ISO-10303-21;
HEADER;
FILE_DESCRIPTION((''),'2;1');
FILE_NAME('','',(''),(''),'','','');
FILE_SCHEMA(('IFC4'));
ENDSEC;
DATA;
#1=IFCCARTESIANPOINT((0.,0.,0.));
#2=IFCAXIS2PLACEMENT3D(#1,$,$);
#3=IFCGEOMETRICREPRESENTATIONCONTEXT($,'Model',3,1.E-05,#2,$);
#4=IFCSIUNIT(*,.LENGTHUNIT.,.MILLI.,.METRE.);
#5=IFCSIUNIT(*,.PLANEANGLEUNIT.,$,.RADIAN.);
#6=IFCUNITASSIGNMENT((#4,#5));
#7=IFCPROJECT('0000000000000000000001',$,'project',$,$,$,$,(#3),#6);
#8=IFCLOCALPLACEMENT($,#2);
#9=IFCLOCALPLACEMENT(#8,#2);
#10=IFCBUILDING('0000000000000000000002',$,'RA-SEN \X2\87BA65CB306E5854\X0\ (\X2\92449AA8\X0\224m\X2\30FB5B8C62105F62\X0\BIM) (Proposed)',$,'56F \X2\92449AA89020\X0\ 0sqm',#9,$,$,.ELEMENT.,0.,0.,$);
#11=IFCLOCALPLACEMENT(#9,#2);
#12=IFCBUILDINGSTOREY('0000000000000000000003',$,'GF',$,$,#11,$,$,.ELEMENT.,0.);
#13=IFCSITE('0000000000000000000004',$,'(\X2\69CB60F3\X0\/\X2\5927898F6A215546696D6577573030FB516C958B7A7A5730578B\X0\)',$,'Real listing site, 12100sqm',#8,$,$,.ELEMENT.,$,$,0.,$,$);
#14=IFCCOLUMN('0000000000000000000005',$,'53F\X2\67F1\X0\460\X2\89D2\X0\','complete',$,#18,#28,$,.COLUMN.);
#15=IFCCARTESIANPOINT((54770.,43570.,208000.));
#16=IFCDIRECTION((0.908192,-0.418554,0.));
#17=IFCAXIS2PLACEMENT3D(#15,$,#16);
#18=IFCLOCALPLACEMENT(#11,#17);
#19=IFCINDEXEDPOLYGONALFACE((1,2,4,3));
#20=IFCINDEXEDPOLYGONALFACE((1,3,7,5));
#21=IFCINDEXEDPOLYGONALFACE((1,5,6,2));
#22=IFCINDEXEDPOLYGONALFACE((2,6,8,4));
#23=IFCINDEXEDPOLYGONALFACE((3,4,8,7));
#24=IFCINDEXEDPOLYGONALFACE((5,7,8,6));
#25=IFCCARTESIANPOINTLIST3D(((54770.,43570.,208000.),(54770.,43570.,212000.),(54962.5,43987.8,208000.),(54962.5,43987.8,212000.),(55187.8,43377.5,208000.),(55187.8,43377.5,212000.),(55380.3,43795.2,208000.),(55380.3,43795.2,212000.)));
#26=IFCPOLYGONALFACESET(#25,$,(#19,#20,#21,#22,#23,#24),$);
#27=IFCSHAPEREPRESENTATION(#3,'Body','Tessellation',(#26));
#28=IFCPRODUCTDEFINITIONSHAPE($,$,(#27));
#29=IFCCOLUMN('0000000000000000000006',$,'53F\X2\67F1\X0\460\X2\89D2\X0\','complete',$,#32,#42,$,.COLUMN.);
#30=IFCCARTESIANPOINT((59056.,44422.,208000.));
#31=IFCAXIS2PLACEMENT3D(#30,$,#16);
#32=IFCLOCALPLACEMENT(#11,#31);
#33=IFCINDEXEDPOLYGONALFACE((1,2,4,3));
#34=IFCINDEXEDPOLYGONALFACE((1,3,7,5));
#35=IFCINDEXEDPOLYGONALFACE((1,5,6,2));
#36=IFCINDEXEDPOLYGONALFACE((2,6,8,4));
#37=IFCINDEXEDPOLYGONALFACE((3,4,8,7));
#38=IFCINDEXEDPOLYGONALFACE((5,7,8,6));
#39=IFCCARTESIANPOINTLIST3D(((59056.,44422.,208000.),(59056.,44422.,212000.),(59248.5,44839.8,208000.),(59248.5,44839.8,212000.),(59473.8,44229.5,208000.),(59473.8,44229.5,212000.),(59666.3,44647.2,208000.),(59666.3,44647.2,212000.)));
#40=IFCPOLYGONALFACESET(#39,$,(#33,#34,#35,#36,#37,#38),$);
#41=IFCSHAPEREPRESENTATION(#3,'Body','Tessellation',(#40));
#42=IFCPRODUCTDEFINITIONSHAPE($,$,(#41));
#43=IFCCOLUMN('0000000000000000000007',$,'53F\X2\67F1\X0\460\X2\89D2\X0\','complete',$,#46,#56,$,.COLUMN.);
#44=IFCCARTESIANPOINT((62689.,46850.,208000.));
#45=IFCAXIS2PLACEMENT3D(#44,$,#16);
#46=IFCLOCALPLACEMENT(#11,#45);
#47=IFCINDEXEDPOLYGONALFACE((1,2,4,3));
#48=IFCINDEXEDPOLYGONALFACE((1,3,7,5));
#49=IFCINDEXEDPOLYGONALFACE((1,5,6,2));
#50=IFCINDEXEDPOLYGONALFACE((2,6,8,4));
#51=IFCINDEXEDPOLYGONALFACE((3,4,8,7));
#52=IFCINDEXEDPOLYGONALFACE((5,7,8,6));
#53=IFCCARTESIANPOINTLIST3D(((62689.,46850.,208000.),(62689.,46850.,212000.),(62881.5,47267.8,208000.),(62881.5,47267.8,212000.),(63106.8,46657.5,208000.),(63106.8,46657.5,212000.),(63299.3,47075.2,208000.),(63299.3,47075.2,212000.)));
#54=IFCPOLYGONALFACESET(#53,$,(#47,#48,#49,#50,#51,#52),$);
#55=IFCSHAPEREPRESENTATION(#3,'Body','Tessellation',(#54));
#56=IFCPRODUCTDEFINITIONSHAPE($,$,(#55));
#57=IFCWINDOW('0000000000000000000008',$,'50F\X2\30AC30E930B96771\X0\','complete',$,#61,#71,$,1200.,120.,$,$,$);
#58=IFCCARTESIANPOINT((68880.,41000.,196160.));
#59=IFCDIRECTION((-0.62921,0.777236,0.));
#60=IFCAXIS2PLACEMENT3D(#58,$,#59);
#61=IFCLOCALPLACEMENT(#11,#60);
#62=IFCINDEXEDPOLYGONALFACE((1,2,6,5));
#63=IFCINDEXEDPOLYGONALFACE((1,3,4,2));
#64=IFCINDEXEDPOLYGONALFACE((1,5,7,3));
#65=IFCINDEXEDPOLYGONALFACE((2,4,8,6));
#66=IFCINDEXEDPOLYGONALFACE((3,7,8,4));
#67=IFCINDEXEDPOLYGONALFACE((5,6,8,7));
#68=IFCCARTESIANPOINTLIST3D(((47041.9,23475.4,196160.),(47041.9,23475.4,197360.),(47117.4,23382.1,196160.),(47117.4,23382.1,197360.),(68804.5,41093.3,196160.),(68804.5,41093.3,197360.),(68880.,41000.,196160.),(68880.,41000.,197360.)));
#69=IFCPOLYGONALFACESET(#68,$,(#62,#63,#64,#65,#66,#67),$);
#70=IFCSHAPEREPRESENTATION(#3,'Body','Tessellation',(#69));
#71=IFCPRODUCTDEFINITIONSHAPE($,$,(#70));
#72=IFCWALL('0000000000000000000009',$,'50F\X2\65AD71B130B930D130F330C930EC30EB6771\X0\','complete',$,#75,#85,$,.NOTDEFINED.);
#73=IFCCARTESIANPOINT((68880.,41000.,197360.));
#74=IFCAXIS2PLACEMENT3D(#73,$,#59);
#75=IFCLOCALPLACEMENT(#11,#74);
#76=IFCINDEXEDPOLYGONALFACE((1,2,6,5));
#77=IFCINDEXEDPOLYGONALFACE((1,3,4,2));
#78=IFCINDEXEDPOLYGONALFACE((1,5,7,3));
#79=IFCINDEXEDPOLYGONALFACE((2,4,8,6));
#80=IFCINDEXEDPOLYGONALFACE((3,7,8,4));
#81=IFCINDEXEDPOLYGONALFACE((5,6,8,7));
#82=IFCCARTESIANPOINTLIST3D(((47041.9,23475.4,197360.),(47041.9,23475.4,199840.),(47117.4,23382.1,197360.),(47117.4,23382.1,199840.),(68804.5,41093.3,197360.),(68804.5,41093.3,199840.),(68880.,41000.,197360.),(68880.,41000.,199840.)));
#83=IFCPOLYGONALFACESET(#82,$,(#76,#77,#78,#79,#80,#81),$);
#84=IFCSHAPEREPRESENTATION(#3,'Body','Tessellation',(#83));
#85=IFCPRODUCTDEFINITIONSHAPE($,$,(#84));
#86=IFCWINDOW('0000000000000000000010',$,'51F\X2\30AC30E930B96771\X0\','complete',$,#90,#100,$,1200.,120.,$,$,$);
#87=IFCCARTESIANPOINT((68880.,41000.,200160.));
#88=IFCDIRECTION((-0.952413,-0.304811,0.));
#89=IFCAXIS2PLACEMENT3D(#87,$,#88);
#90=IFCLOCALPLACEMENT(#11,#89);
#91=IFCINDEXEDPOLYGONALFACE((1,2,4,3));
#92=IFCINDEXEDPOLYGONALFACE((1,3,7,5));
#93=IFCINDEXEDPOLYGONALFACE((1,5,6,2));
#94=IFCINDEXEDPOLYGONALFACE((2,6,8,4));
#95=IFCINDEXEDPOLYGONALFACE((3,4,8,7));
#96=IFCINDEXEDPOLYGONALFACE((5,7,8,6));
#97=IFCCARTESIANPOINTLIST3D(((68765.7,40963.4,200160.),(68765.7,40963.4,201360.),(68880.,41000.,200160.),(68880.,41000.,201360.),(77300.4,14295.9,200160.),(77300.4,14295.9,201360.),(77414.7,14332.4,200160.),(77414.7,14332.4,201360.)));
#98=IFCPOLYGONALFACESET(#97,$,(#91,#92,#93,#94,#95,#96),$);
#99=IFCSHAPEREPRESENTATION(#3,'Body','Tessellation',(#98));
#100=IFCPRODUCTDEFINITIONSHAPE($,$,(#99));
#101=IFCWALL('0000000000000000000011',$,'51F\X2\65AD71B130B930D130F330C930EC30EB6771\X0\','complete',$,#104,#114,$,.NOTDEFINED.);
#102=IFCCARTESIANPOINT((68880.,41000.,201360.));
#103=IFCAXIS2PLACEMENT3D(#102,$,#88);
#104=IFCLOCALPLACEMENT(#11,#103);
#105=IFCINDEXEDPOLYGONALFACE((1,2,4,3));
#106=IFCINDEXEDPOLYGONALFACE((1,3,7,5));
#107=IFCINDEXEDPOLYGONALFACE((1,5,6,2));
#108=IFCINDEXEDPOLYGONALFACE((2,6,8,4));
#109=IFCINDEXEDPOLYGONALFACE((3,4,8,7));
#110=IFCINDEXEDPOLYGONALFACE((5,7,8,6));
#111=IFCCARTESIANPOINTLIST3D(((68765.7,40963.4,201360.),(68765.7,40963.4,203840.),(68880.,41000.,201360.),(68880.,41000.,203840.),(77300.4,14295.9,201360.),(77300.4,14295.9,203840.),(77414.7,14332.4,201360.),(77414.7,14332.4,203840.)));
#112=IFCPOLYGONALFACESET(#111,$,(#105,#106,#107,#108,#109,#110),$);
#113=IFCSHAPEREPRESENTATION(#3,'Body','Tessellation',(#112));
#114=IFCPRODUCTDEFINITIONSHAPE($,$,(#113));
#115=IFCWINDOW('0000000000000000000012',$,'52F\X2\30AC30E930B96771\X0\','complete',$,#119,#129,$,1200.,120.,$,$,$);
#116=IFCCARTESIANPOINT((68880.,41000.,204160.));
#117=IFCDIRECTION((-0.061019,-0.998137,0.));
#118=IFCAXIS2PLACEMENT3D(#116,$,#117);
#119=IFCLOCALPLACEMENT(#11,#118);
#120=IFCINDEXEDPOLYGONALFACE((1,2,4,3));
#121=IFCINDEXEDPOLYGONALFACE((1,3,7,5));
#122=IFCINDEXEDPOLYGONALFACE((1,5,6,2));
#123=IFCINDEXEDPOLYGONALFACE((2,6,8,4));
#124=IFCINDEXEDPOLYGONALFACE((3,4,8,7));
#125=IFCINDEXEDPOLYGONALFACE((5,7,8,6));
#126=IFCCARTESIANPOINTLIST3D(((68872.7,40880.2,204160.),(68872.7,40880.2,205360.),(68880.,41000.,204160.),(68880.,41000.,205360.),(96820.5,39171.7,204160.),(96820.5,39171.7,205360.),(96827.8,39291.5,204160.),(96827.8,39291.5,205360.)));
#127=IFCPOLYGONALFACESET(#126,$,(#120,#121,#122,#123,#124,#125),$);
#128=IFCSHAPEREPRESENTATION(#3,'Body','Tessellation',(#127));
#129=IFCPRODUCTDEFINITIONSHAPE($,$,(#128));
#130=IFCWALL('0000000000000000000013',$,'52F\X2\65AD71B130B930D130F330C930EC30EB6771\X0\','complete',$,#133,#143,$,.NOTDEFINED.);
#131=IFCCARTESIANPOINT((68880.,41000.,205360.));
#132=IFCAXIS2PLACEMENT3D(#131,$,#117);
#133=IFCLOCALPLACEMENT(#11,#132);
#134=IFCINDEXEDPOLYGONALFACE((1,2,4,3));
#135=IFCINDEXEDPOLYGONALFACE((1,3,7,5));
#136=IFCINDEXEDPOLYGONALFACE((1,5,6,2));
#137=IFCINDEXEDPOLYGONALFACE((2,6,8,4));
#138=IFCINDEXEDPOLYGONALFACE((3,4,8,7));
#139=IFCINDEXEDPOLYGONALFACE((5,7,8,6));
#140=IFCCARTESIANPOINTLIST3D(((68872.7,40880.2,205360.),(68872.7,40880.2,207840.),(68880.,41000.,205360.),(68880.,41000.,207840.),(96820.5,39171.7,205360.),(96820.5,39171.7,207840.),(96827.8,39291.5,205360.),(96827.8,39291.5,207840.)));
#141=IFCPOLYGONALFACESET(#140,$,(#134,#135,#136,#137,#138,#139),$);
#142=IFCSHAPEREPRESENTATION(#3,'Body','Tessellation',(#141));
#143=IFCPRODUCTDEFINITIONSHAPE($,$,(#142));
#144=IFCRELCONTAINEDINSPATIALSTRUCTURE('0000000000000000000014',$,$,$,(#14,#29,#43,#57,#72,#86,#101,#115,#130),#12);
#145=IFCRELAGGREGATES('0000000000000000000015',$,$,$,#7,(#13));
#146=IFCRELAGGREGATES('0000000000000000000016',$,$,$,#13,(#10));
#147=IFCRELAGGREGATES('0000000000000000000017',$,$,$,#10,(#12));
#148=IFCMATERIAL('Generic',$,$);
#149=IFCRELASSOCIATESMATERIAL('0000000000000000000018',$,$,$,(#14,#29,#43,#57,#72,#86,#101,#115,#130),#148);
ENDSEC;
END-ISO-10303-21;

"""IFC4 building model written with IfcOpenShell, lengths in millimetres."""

from ifc_helpers import new_model, si_unit, frame, frame_2d, origin, place, context, project, spatial, rectangle, extrude, material, element, save


model = new_model("IFC4")

# Units and contexts
model_context = context("Model", 3, precision=1e-05, world=origin())
ifc_project = project(units=[si_unit("LENGTHUNIT", "METRE", prefix="MILLI"), si_unit("PLANEANGLEUNIT", "RADIAN")], contexts=[model_context])

# Site, building, storey
site_placement = place(None, origin())
site = spatial("IfcSite", under=ifc_project, at=site_placement, Name="(構想/大規模商業敷地・公開空地型)", ObjectType="Real listing site, 12100sqm", CompositionType="ELEMENT", RefElevation=0.0)
building_placement = place(site_placement, origin())
building = spatial("IfcBuilding", under=site, at=building_placement, Name="RA-SEN 螺旋の塔 (鉄骨224m・完成形BIM) (Proposed)", ObjectType="56F 鉄骨造 0sqm", CompositionType="ELEMENT", ElevationOfRefHeight=0.0, ElevationOfTerrain=0.0)
storey_placement = place(building_placement, origin())
storey = spatial("IfcBuildingStorey", under=building, at=storey_placement, Name="GF", CompositionType="ELEMENT", Elevation=0.0)

# Columns
ifc_material = material(Name="Generic")
column_1_placement = place(storey_placement, frame((54770.0, 43570.0, 208000.0), x_axis=(0.908192, -0.418554, 0.0)))
element("IfcColumn", 1, at=column_1_placement, inside=storey, material=ifc_material, Name="53F柱460角", Description="complete", PredefinedType="COLUMN", context=model_context, shape_type="SweptSolid", body=[
    extrude(rectangle(XDim=460.0, YDim=460.0, at=frame_2d((230.0, 230.0))), frame((54770.0, 43570.0, 208000.0), x_axis=(0.908192, -0.418554, 0.0)), (0.0, 0.0, 1.0), 4000.0),
])
column_2_placement = place(storey_placement, frame((59056.0, 44422.0, 208000.0), x_axis=(0.908192, -0.418554, 0.0)))
element("IfcColumn", 2, at=column_2_placement, inside=storey, material=ifc_material, Name="53F柱460角", Description="complete", PredefinedType="COLUMN", context=model_context, shape_type="SweptSolid", body=[
    extrude(rectangle(XDim=460.0, YDim=460.0, at=frame_2d((230.0, 230.0))), frame((59056.0, 44422.0, 208000.0), x_axis=(0.908192, -0.418554, 0.0)), (0.0, 0.0, 1.0), 4000.0),
])
column_3_placement = place(storey_placement, frame((62689.0, 46850.0, 208000.0), x_axis=(0.908192, -0.418554, 0.0)))
element("IfcColumn", 3, at=column_3_placement, inside=storey, material=ifc_material, Name="53F柱460角", Description="complete", PredefinedType="COLUMN", context=model_context, shape_type="SweptSolid", body=[
    extrude(rectangle(XDim=460.0, YDim=460.0, at=frame_2d((230.0, 230.0))), frame((62689.0, 46850.0, 208000.0), x_axis=(0.908192, -0.418554, 0.0)), (0.0, 0.0, 1.0), 4000.0),
])

# Window
window_1_placement = place(storey_placement, frame((68880.0, 41000.0, 196160.0), x_axis=(-0.62921, 0.777236, 0.0)))
element("IfcWindow", 4, at=window_1_placement, inside=storey, material=ifc_material, Name="50Fガラス東", Description="complete", OverallHeight=1200.0, OverallWidth=120.0, context=model_context, shape_type="SweptSolid", body=[
    extrude(rectangle(XDim=120.0, YDim=28000.0, at=frame_2d((60.0, 14000.0))), frame((68880.0, 41000.0, 196160.0), x_axis=(-0.62921, 0.777236, 0.0)), (0.0, 0.0, 1.0), 1200.0),
])

# Wall
wall_1_placement = place(storey_placement, frame((68880.0, 41000.0, 197360.0), x_axis=(-0.62921, 0.777236, 0.0)))
element("IfcWall", 5, at=wall_1_placement, inside=storey, material=ifc_material, Name="50F断熱スパンドレル東", Description="complete", PredefinedType="NOTDEFINED", context=model_context, shape_type="SweptSolid", body=[
    extrude(rectangle(XDim=120.0, YDim=28000.0, at=frame_2d((60.0, 14000.0))), frame((68880.0, 41000.0, 197360.0), x_axis=(-0.62921, 0.777236, 0.0)), (0.0, 0.0, 1.0), 2480.0),
])

# Window
window_2_placement = place(storey_placement, frame((68880.0, 41000.0, 200160.0), x_axis=(-0.952413, -0.304811, 0.0)))
element("IfcWindow", 6, at=window_2_placement, inside=storey, material=ifc_material, Name="51Fガラス東", Description="complete", OverallHeight=1200.0, OverallWidth=120.0, context=model_context, shape_type="SweptSolid", body=[
    extrude(rectangle(XDim=120.0, YDim=28000.0, at=frame_2d((60.0, 14000.0))), frame((68880.0, 41000.0, 200160.0), x_axis=(-0.952413, -0.304811, 0.0)), (0.0, 0.0, 1.0), 1200.0),
])

# Wall
wall_2_placement = place(storey_placement, frame((68880.0, 41000.0, 201360.0), x_axis=(-0.952413, -0.304811, 0.0)))
element("IfcWall", 7, at=wall_2_placement, inside=storey, material=ifc_material, Name="51F断熱スパンドレル東", Description="complete", PredefinedType="NOTDEFINED", context=model_context, shape_type="SweptSolid", body=[
    extrude(rectangle(XDim=120.0, YDim=28000.0, at=frame_2d((60.0, 14000.0))), frame((68880.0, 41000.0, 201360.0), x_axis=(-0.952413, -0.304811, 0.0)), (0.0, 0.0, 1.0), 2480.0),
])

# Window
window_3_placement = place(storey_placement, frame((68880.0, 41000.0, 204160.0), x_axis=(-0.061019, -0.998137, 0.0)))
element("IfcWindow", 8, at=window_3_placement, inside=storey, material=ifc_material, Name="52Fガラス東", Description="complete", OverallHeight=1200.0, OverallWidth=120.0, context=model_context, shape_type="SweptSolid", body=[
    extrude(rectangle(XDim=120.0, YDim=28000.0, at=frame_2d((60.0, 14000.0))), frame((68880.0, 41000.0, 204160.0), x_axis=(-0.061019, -0.998137, 0.0)), (0.0, 0.0, 1.0), 1200.0),
])

# Wall
wall_3_placement = place(storey_placement, frame((68880.0, 41000.0, 205360.0), x_axis=(-0.061019, -0.998137, 0.0)))
element("IfcWall", 9, at=wall_3_placement, inside=storey, material=ifc_material, Name="52F断熱スパンドレル東", Description="complete", PredefinedType="NOTDEFINED", context=model_context, shape_type="SweptSolid", body=[
    extrude(rectangle(XDim=120.0, YDim=28000.0, at=frame_2d((60.0, 14000.0))), frame((68880.0, 41000.0, 205360.0), x_axis=(-0.061019, -0.998137, 0.0)), (0.0, 0.0, 1.0), 2480.0),
])

save(model, "model.ifc")
